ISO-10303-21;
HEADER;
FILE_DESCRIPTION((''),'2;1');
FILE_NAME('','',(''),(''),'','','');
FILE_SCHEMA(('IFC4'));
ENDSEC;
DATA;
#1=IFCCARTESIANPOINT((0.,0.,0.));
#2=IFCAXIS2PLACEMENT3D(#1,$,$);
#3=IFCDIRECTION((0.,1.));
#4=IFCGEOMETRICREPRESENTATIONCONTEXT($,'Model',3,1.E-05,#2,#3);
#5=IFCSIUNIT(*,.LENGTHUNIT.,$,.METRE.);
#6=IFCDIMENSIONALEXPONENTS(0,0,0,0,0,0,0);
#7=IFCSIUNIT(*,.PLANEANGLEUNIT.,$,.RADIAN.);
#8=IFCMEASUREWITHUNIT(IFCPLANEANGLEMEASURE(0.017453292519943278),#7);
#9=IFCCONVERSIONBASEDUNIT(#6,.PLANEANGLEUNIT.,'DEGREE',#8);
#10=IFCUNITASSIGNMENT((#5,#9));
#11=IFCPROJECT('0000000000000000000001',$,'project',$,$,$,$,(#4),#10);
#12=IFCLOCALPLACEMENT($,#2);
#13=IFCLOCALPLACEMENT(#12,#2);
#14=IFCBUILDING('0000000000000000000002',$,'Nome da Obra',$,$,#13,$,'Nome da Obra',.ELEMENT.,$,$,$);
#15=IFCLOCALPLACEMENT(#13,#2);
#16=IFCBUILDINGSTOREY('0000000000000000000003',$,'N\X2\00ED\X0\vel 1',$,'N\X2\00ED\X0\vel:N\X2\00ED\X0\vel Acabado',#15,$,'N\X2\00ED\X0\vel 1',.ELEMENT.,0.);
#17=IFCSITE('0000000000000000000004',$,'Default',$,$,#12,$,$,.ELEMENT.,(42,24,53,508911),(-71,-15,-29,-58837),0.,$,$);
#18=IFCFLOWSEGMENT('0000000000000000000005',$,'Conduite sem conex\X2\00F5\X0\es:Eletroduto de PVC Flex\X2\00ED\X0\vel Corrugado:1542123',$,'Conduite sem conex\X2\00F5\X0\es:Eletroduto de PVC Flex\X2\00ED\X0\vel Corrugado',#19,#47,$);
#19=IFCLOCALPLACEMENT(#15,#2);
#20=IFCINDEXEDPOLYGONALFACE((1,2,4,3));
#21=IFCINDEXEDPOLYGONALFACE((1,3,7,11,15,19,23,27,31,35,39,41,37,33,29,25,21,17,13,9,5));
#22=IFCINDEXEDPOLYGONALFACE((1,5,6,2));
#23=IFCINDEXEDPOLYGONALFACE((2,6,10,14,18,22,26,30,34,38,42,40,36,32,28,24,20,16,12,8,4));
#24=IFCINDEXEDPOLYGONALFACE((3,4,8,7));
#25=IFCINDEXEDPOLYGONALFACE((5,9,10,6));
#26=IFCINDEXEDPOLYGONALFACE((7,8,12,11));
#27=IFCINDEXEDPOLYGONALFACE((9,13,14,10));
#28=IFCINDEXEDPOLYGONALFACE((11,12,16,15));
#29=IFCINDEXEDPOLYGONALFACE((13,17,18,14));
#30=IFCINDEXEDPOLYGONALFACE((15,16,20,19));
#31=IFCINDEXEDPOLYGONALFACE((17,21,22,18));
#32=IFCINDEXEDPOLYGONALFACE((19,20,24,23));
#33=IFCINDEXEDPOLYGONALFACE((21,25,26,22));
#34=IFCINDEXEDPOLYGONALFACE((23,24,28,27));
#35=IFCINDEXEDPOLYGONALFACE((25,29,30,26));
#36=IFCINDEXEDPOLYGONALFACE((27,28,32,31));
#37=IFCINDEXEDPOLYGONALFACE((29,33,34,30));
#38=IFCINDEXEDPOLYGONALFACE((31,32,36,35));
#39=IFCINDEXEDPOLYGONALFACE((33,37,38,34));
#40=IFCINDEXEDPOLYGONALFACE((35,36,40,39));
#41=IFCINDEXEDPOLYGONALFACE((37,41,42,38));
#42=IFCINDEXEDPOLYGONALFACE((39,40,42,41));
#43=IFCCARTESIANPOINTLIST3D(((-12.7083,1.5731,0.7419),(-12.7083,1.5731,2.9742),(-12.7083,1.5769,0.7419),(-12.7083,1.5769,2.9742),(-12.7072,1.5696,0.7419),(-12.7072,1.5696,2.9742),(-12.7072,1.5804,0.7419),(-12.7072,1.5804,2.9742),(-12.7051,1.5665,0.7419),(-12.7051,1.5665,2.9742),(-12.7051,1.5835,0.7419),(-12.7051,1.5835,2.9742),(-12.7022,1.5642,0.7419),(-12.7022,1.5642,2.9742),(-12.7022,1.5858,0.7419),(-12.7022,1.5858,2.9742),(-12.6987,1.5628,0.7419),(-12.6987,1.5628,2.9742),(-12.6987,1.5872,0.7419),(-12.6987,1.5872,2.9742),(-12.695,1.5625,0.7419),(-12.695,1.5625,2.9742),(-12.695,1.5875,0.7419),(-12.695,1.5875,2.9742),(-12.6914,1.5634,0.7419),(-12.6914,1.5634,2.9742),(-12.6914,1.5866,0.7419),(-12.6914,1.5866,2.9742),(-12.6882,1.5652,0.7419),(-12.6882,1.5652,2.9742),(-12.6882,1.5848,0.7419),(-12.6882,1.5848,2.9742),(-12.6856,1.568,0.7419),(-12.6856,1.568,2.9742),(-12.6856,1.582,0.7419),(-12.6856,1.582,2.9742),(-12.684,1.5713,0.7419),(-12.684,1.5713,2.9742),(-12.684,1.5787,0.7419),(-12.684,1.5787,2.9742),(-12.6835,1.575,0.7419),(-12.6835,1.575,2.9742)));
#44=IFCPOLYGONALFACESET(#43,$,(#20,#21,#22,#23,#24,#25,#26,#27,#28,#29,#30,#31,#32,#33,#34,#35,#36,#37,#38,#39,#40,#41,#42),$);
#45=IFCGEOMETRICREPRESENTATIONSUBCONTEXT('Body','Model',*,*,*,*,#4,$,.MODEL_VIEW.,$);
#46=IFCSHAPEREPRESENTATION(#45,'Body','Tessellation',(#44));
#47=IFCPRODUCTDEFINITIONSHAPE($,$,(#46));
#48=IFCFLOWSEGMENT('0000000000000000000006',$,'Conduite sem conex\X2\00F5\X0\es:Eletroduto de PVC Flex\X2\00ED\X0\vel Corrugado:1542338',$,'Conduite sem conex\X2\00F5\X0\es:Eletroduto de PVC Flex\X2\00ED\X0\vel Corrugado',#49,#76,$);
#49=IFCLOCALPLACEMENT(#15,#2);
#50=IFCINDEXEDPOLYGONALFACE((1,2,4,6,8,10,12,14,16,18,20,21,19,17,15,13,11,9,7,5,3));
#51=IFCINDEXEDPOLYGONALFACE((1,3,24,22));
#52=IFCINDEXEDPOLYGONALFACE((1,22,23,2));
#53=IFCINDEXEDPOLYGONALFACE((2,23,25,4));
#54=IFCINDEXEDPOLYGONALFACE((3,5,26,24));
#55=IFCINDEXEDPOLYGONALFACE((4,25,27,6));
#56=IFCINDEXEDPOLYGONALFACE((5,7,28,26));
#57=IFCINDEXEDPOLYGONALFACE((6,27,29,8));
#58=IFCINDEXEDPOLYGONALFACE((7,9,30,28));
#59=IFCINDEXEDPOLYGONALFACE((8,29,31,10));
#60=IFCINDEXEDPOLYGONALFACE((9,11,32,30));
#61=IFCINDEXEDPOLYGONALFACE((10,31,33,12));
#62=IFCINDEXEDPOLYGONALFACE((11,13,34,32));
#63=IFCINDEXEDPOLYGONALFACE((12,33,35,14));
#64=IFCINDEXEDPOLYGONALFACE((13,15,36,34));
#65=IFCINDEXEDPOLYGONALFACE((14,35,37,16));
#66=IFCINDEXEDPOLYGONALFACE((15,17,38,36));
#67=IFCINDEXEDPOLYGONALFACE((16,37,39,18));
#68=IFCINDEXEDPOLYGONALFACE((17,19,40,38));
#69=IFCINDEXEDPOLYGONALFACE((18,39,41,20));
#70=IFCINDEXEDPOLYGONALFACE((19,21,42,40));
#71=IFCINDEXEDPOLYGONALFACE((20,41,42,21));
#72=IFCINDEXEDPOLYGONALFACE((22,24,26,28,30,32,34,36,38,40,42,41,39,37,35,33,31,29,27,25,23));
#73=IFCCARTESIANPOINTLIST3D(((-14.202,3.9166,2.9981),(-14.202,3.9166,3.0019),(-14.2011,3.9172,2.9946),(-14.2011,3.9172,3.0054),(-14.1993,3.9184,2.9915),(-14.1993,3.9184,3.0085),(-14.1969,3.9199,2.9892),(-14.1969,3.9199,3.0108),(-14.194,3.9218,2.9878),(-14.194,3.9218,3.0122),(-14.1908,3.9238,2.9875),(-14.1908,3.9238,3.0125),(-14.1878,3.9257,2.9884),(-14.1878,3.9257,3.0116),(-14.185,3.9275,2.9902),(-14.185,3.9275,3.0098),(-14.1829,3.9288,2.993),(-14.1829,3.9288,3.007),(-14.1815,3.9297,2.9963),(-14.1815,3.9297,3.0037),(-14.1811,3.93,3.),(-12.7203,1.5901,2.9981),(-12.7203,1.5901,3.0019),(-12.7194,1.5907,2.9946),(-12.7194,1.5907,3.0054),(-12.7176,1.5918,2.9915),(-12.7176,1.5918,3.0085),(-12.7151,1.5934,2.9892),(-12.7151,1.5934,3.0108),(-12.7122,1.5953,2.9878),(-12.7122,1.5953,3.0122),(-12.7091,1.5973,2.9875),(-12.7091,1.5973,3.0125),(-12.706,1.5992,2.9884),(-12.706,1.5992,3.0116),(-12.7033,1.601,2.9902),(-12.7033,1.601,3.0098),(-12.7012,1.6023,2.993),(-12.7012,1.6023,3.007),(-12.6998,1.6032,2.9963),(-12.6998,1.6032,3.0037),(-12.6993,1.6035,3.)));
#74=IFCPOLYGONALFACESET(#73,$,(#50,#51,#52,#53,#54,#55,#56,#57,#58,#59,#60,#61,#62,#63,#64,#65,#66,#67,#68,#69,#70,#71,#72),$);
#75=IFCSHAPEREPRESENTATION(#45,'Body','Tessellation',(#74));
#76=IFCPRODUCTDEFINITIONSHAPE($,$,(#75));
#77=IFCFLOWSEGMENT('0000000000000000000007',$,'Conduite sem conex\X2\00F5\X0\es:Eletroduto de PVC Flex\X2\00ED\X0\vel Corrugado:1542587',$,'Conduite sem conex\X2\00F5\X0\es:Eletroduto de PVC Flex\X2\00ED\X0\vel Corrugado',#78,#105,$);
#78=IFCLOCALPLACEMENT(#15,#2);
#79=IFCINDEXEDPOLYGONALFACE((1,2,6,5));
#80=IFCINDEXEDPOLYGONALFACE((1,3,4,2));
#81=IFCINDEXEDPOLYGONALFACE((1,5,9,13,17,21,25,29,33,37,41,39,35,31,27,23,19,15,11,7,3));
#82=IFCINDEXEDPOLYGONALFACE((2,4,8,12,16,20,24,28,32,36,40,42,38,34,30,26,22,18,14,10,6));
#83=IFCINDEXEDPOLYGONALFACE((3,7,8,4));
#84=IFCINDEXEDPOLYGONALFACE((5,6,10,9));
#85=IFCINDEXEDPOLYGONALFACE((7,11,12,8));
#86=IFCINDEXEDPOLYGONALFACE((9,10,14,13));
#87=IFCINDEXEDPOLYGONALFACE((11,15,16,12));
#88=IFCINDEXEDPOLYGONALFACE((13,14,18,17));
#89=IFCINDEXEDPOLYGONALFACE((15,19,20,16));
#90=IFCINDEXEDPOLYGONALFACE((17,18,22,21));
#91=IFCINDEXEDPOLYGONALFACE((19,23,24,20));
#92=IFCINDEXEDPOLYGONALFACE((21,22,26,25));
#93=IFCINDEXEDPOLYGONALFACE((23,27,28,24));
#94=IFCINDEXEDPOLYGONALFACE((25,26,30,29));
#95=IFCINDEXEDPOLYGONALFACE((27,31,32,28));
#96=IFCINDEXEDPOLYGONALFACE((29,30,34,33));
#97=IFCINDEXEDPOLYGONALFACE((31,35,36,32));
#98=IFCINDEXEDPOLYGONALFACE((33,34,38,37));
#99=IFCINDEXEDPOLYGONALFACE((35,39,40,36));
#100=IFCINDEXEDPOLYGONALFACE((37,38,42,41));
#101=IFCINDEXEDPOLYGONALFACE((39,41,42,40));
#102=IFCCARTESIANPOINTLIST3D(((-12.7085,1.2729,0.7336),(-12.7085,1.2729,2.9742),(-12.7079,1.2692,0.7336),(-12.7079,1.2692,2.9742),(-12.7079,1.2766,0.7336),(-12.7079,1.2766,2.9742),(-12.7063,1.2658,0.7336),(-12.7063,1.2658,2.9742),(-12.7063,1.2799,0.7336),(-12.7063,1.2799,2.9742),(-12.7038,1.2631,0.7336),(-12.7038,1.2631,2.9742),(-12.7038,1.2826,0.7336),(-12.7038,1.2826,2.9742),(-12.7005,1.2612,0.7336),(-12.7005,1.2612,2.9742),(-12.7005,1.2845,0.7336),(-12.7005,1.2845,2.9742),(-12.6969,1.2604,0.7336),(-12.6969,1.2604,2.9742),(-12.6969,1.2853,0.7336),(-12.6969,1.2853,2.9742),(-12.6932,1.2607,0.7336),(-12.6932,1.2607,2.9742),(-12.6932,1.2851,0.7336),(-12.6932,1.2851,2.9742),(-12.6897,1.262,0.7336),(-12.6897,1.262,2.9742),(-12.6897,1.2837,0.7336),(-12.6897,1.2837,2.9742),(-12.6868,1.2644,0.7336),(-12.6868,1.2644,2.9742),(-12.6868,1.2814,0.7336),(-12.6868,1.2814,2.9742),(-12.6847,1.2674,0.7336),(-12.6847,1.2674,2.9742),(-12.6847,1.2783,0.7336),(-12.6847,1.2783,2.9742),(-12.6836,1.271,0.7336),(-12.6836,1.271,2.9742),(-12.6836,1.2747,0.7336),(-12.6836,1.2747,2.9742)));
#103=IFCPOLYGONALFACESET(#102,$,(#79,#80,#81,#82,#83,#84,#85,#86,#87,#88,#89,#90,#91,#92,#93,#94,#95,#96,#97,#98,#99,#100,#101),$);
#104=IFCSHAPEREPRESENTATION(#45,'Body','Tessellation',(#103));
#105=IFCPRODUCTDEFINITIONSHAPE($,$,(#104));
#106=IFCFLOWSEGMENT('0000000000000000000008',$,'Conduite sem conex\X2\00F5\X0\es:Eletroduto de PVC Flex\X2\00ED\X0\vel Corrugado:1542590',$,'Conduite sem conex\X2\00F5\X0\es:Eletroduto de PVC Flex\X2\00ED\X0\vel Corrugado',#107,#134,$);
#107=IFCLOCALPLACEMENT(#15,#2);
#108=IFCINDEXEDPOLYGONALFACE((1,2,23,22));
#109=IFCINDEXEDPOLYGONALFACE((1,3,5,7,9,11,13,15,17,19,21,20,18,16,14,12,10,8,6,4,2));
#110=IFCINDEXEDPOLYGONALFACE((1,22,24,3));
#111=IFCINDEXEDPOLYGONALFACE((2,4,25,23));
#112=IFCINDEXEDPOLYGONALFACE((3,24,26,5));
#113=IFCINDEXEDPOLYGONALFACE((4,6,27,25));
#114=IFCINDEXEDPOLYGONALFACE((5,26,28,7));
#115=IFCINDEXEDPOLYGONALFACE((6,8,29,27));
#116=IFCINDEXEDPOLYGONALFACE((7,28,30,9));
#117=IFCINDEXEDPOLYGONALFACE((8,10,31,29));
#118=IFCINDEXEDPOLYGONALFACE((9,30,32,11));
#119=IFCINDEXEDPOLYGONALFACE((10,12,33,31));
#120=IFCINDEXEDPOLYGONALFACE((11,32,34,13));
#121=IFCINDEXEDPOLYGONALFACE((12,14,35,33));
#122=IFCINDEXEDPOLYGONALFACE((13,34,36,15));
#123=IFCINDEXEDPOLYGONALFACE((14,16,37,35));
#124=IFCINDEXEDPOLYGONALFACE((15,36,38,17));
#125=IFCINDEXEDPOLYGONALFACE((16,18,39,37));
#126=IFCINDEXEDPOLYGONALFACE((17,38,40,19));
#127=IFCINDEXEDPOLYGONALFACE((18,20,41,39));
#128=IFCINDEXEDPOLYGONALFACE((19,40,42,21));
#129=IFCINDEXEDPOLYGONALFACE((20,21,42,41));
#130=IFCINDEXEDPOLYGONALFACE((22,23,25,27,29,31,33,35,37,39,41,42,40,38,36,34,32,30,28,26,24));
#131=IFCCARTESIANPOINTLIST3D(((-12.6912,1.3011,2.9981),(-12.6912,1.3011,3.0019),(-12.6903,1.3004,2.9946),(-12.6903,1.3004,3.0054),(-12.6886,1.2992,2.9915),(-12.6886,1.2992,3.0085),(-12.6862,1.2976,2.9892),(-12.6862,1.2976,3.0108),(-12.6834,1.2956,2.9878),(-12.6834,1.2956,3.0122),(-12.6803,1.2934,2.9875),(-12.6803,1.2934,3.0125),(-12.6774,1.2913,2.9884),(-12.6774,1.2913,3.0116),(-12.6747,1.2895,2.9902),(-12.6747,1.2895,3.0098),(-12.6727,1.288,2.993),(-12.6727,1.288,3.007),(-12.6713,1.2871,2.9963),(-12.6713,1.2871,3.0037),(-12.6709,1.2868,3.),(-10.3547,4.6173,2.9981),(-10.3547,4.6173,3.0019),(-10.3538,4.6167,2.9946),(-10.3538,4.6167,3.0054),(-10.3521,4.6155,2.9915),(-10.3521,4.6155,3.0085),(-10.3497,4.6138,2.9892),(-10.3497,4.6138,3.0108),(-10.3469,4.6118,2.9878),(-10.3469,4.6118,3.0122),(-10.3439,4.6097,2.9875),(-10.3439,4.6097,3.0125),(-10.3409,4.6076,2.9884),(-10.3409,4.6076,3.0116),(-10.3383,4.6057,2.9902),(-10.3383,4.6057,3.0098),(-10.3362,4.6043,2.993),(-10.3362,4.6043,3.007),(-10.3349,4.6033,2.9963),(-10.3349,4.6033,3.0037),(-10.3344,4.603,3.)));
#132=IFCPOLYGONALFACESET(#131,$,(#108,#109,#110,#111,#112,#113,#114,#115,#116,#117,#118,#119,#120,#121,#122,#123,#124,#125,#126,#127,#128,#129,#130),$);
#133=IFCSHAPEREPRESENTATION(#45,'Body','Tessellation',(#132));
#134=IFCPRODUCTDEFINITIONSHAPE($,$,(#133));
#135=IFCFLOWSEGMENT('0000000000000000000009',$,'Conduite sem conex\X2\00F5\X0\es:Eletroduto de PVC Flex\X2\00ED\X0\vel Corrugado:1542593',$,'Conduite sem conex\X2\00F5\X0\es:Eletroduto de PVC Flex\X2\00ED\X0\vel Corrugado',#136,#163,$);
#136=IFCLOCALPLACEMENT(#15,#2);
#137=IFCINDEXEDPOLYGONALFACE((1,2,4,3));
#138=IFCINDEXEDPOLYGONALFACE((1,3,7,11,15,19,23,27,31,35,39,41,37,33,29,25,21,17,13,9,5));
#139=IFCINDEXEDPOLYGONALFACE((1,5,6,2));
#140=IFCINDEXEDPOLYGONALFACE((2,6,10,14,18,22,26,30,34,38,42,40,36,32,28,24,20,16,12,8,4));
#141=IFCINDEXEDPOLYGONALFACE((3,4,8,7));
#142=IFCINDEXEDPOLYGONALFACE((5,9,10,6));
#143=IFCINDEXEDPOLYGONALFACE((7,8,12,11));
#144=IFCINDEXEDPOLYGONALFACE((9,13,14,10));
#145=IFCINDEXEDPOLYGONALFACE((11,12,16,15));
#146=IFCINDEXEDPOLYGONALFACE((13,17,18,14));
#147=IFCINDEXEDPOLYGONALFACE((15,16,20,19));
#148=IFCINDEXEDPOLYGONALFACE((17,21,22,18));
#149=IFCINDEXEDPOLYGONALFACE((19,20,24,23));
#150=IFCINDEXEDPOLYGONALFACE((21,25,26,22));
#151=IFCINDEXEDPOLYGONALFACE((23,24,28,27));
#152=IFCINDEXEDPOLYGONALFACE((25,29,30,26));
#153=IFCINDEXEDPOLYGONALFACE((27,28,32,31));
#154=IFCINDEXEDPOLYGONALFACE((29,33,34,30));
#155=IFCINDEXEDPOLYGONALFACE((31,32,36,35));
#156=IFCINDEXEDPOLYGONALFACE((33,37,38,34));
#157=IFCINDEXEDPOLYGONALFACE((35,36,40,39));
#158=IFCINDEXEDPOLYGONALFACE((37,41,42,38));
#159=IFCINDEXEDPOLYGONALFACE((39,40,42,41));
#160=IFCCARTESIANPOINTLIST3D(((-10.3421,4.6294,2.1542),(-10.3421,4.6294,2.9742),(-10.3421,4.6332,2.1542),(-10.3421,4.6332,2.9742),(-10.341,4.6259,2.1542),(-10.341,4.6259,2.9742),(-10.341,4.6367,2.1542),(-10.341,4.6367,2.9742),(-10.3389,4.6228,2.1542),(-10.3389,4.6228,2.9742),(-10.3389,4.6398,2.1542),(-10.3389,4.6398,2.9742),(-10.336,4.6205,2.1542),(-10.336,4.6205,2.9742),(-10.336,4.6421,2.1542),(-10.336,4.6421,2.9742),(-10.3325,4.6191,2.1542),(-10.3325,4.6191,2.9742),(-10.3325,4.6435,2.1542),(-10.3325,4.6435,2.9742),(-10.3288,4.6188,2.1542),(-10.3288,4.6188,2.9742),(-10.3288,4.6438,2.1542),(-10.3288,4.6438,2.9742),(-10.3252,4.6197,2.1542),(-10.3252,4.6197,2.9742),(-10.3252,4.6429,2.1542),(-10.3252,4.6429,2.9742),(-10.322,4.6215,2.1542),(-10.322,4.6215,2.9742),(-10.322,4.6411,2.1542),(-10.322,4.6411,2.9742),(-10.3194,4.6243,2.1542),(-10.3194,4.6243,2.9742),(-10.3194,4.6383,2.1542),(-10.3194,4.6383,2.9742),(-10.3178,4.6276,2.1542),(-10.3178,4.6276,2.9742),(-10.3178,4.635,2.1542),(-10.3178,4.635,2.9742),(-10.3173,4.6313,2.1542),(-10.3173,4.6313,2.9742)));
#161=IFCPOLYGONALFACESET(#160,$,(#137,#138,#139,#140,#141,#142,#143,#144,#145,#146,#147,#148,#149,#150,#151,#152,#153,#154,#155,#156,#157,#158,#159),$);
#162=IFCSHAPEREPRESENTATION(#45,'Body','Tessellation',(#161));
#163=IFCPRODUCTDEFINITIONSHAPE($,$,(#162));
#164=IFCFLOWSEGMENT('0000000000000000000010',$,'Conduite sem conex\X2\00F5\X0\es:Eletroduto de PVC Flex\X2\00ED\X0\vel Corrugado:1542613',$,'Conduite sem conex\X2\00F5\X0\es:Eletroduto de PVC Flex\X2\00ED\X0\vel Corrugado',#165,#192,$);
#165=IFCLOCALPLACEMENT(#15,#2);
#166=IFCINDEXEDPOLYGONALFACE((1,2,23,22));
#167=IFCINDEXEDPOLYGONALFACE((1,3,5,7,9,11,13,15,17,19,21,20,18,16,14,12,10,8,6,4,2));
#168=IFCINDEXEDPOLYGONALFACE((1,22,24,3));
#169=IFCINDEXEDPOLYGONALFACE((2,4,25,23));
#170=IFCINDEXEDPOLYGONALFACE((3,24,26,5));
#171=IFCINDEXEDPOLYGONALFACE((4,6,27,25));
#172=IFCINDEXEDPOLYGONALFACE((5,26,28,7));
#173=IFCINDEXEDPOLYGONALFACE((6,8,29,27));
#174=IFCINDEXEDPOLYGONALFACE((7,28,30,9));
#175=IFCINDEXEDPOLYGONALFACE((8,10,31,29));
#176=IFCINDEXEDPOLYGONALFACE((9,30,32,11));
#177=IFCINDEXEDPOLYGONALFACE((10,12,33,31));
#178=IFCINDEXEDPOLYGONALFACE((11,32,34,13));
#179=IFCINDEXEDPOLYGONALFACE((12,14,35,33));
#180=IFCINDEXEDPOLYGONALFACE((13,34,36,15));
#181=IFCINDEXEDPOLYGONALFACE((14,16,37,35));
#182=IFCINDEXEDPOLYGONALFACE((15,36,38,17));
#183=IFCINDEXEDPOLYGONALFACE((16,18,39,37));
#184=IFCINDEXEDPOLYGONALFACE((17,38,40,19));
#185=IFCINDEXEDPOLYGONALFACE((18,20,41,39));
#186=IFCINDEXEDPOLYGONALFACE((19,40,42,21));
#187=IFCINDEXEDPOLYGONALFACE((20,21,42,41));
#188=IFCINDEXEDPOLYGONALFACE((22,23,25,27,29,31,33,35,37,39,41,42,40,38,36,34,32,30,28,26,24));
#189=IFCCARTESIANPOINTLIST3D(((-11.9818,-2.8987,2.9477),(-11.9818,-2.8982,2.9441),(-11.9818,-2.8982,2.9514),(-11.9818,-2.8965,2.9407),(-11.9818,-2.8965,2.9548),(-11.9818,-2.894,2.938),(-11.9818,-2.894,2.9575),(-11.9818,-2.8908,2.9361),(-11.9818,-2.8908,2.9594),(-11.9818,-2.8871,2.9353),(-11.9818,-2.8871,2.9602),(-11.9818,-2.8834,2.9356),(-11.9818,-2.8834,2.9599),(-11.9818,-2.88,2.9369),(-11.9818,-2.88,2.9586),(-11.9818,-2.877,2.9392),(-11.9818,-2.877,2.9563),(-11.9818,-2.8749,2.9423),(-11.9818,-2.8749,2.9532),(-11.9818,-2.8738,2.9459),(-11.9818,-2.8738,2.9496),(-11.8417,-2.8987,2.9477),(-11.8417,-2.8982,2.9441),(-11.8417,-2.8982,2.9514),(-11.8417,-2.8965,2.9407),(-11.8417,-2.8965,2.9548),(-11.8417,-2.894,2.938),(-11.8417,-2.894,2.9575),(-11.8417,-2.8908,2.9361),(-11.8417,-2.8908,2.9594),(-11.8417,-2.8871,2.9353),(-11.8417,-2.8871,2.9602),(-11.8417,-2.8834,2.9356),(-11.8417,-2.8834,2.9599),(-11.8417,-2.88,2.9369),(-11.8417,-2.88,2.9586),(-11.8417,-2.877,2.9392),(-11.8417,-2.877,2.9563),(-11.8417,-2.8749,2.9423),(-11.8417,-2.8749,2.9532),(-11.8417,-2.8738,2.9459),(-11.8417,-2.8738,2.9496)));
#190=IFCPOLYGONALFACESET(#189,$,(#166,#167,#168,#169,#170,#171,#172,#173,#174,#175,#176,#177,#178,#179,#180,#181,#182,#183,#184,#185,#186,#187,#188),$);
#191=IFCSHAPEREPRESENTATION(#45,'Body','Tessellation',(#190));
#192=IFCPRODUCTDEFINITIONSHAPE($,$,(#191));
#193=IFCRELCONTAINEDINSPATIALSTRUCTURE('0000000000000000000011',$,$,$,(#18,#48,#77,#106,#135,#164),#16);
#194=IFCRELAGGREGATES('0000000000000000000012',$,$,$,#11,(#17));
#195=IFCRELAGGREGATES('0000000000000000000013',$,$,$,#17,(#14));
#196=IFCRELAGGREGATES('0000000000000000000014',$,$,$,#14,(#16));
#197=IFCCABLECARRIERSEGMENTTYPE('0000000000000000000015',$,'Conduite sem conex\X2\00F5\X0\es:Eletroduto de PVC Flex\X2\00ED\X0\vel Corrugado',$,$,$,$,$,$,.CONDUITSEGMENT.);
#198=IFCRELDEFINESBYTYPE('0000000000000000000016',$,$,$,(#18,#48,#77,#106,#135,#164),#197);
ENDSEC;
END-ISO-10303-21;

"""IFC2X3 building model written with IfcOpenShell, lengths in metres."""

from ifc_helpers import new_model, entity, si_unit, converted_unit, direction, frame, frame_2d, origin, origin_2d_with_axis, place, context, subcontext, project, spatial, circle, extrude, type_object, element, save


model = new_model("IFC2X3")

# Units and contexts
model_context = context("Model", 3, precision=1e-05, world=origin(), true_north=direction((0.0, 1.0)))
body_context = subcontext(model_context, "Body", "Model", "MODEL_VIEW")
ifc_project = project(units=[si_unit("LENGTHUNIT", "METRE"), converted_unit("PLANEANGLEUNIT", "DEGREE", entity("IfcPlaneAngleMeasure", 0.017453292519943278), si_unit("PLANEANGLEUNIT", "RADIAN"), dimensions=[0, 0, 0, 0, 0, 0, 0])], contexts=[model_context])

# Site, building, storey
site_placement = place(None, origin())
site = spatial("IfcSite", under=ifc_project, at=site_placement, Name="Default", CompositionType="ELEMENT", RefLatitude=(42, 24, 53, 508911), RefLongitude=(-71, -15, -29, -58837), RefElevation=0.0)
building_placement = place(site_placement, origin())
building = spatial("IfcBuilding", under=site, at=building_placement, Name="Nome da Obra", LongName="Nome da Obra", CompositionType="ELEMENT")
storey_placement = place(building_placement, origin())
storey = spatial("IfcBuildingStorey", under=building, at=storey_placement, Name="Nível 1", ObjectType="Nível:Nível Acabado", LongName="Nível 1", CompositionType="ELEMENT", Elevation=0.0)

# Flow segments
cable_carrier_segment_type = type_object("IfcCableCarrierSegmentType", Name="Conduite sem conexões:Eletroduto de PVC Flexível Corrugado", PredefinedType="CONDUITSEGMENT")
flow_segment_1_placement = place(storey_placement, origin())
element("IfcFlowSegment", 1, at=flow_segment_1_placement, inside=storey, type_object=cable_carrier_segment_type, Name="Conduite sem conexões:Eletroduto de PVC Flexível Corrugado:1542123", ObjectType="Conduite sem conexões:Eletroduto de PVC Flexível Corrugado", context=body_context, shape_type="SweptSolid", body=[
    extrude(circle(Radius=0.0125, at=origin_2d_with_axis()), frame((-12.696, 1.575, 0.7419)), (0.0, 0.0, 1.0), 2.2323),
])
flow_segment_2_placement = place(storey_placement, origin())
element("IfcFlowSegment", 2, at=flow_segment_2_placement, inside=storey, type_object=cable_carrier_segment_type, Name="Conduite sem conexões:Eletroduto de PVC Flexível Corrugado:1542338", ObjectType="Conduite sem conexões:Eletroduto de PVC Flexível Corrugado", context=body_context, shape_type="SweptSolid", body=[
    extrude(circle(Radius=0.0125, at=frame_2d((0.0, 0.0), x_axis=(1.0, 0.0))), frame((-14.1916, 3.9233, 3.0), z_axis=(0.537194, -0.843458, 0.0), x_axis=(0.843458, 0.537194, 0.0)), (0.0, 0.0, 1.0), 2.7583),
])
flow_segment_3_placement = place(storey_placement, origin())
element("IfcFlowSegment", 3, at=flow_segment_3_placement, inside=storey, type_object=cable_carrier_segment_type, Name="Conduite sem conexões:Eletroduto de PVC Flexível Corrugado:1542587", ObjectType="Conduite sem conexões:Eletroduto de PVC Flexível Corrugado", context=body_context, shape_type="SweptSolid", body=[
    extrude(circle(Radius=0.0125, at=origin_2d_with_axis()), frame((-12.696, 1.2729, 0.7336), z_axis=(0.0, 0.0, 1.0), x_axis=(-1.0, 0.0, 0.0)), (0.0, 0.0, 1.0), 2.2406),
])
flow_segment_4_placement = place(storey_placement, origin())
element("IfcFlowSegment", 4, at=flow_segment_4_placement, inside=storey, type_object=cable_carrier_segment_type, Name="Conduite sem conexões:Eletroduto de PVC Flexível Corrugado:1542590", ObjectType="Conduite sem conexões:Eletroduto de PVC Flexível Corrugado", context=body_context, shape_type="SweptSolid", body=[
    extrude(circle(Radius=0.0125, at=frame_2d((0.0, 0.0), x_axis=(1.0, 0.0))), frame((-12.6811, 1.294, 3.0), z_axis=(0.575959, 0.817479, 0.0), x_axis=(0.817479, -0.575959, 0.0)), (0.0, 0.0, 1.0), 4.0567),
])
flow_segment_5_placement = place(storey_placement, origin())
element("IfcFlowSegment", 5, at=flow_segment_5_placement, inside=storey, type_object=cable_carrier_segment_type, Name="Conduite sem conexões:Eletroduto de PVC Flexível Corrugado:1542593", ObjectType="Conduite sem conexões:Eletroduto de PVC Flexível Corrugado", context=body_context, shape_type="SweptSolid", body=[
    extrude(circle(Radius=0.0125, at=origin_2d_with_axis()), frame((-10.3298, 4.6313, 2.1542)), (0.0, 0.0, 1.0), 0.82),
])
flow_segment_6_placement = place(storey_placement, origin())
element("IfcFlowSegment", 6, at=flow_segment_6_placement, inside=storey, type_object=cable_carrier_segment_type, Name="Conduite sem conexões:Eletroduto de PVC Flexível Corrugado:1542613", ObjectType="Conduite sem conexões:Eletroduto de PVC Flexível Corrugado", context=body_context, shape_type="SweptSolid", body=[
    extrude(circle(Radius=0.0125, at=origin_2d_with_axis()), frame((-11.9818, -2.8862, 2.9477), z_axis=(1.0, 0.0, 0.0), x_axis=(0.0, -1.0, 0.0)), (0.0, 0.0, 1.0), 0.1402),
])

save(model, "model.ifc")
